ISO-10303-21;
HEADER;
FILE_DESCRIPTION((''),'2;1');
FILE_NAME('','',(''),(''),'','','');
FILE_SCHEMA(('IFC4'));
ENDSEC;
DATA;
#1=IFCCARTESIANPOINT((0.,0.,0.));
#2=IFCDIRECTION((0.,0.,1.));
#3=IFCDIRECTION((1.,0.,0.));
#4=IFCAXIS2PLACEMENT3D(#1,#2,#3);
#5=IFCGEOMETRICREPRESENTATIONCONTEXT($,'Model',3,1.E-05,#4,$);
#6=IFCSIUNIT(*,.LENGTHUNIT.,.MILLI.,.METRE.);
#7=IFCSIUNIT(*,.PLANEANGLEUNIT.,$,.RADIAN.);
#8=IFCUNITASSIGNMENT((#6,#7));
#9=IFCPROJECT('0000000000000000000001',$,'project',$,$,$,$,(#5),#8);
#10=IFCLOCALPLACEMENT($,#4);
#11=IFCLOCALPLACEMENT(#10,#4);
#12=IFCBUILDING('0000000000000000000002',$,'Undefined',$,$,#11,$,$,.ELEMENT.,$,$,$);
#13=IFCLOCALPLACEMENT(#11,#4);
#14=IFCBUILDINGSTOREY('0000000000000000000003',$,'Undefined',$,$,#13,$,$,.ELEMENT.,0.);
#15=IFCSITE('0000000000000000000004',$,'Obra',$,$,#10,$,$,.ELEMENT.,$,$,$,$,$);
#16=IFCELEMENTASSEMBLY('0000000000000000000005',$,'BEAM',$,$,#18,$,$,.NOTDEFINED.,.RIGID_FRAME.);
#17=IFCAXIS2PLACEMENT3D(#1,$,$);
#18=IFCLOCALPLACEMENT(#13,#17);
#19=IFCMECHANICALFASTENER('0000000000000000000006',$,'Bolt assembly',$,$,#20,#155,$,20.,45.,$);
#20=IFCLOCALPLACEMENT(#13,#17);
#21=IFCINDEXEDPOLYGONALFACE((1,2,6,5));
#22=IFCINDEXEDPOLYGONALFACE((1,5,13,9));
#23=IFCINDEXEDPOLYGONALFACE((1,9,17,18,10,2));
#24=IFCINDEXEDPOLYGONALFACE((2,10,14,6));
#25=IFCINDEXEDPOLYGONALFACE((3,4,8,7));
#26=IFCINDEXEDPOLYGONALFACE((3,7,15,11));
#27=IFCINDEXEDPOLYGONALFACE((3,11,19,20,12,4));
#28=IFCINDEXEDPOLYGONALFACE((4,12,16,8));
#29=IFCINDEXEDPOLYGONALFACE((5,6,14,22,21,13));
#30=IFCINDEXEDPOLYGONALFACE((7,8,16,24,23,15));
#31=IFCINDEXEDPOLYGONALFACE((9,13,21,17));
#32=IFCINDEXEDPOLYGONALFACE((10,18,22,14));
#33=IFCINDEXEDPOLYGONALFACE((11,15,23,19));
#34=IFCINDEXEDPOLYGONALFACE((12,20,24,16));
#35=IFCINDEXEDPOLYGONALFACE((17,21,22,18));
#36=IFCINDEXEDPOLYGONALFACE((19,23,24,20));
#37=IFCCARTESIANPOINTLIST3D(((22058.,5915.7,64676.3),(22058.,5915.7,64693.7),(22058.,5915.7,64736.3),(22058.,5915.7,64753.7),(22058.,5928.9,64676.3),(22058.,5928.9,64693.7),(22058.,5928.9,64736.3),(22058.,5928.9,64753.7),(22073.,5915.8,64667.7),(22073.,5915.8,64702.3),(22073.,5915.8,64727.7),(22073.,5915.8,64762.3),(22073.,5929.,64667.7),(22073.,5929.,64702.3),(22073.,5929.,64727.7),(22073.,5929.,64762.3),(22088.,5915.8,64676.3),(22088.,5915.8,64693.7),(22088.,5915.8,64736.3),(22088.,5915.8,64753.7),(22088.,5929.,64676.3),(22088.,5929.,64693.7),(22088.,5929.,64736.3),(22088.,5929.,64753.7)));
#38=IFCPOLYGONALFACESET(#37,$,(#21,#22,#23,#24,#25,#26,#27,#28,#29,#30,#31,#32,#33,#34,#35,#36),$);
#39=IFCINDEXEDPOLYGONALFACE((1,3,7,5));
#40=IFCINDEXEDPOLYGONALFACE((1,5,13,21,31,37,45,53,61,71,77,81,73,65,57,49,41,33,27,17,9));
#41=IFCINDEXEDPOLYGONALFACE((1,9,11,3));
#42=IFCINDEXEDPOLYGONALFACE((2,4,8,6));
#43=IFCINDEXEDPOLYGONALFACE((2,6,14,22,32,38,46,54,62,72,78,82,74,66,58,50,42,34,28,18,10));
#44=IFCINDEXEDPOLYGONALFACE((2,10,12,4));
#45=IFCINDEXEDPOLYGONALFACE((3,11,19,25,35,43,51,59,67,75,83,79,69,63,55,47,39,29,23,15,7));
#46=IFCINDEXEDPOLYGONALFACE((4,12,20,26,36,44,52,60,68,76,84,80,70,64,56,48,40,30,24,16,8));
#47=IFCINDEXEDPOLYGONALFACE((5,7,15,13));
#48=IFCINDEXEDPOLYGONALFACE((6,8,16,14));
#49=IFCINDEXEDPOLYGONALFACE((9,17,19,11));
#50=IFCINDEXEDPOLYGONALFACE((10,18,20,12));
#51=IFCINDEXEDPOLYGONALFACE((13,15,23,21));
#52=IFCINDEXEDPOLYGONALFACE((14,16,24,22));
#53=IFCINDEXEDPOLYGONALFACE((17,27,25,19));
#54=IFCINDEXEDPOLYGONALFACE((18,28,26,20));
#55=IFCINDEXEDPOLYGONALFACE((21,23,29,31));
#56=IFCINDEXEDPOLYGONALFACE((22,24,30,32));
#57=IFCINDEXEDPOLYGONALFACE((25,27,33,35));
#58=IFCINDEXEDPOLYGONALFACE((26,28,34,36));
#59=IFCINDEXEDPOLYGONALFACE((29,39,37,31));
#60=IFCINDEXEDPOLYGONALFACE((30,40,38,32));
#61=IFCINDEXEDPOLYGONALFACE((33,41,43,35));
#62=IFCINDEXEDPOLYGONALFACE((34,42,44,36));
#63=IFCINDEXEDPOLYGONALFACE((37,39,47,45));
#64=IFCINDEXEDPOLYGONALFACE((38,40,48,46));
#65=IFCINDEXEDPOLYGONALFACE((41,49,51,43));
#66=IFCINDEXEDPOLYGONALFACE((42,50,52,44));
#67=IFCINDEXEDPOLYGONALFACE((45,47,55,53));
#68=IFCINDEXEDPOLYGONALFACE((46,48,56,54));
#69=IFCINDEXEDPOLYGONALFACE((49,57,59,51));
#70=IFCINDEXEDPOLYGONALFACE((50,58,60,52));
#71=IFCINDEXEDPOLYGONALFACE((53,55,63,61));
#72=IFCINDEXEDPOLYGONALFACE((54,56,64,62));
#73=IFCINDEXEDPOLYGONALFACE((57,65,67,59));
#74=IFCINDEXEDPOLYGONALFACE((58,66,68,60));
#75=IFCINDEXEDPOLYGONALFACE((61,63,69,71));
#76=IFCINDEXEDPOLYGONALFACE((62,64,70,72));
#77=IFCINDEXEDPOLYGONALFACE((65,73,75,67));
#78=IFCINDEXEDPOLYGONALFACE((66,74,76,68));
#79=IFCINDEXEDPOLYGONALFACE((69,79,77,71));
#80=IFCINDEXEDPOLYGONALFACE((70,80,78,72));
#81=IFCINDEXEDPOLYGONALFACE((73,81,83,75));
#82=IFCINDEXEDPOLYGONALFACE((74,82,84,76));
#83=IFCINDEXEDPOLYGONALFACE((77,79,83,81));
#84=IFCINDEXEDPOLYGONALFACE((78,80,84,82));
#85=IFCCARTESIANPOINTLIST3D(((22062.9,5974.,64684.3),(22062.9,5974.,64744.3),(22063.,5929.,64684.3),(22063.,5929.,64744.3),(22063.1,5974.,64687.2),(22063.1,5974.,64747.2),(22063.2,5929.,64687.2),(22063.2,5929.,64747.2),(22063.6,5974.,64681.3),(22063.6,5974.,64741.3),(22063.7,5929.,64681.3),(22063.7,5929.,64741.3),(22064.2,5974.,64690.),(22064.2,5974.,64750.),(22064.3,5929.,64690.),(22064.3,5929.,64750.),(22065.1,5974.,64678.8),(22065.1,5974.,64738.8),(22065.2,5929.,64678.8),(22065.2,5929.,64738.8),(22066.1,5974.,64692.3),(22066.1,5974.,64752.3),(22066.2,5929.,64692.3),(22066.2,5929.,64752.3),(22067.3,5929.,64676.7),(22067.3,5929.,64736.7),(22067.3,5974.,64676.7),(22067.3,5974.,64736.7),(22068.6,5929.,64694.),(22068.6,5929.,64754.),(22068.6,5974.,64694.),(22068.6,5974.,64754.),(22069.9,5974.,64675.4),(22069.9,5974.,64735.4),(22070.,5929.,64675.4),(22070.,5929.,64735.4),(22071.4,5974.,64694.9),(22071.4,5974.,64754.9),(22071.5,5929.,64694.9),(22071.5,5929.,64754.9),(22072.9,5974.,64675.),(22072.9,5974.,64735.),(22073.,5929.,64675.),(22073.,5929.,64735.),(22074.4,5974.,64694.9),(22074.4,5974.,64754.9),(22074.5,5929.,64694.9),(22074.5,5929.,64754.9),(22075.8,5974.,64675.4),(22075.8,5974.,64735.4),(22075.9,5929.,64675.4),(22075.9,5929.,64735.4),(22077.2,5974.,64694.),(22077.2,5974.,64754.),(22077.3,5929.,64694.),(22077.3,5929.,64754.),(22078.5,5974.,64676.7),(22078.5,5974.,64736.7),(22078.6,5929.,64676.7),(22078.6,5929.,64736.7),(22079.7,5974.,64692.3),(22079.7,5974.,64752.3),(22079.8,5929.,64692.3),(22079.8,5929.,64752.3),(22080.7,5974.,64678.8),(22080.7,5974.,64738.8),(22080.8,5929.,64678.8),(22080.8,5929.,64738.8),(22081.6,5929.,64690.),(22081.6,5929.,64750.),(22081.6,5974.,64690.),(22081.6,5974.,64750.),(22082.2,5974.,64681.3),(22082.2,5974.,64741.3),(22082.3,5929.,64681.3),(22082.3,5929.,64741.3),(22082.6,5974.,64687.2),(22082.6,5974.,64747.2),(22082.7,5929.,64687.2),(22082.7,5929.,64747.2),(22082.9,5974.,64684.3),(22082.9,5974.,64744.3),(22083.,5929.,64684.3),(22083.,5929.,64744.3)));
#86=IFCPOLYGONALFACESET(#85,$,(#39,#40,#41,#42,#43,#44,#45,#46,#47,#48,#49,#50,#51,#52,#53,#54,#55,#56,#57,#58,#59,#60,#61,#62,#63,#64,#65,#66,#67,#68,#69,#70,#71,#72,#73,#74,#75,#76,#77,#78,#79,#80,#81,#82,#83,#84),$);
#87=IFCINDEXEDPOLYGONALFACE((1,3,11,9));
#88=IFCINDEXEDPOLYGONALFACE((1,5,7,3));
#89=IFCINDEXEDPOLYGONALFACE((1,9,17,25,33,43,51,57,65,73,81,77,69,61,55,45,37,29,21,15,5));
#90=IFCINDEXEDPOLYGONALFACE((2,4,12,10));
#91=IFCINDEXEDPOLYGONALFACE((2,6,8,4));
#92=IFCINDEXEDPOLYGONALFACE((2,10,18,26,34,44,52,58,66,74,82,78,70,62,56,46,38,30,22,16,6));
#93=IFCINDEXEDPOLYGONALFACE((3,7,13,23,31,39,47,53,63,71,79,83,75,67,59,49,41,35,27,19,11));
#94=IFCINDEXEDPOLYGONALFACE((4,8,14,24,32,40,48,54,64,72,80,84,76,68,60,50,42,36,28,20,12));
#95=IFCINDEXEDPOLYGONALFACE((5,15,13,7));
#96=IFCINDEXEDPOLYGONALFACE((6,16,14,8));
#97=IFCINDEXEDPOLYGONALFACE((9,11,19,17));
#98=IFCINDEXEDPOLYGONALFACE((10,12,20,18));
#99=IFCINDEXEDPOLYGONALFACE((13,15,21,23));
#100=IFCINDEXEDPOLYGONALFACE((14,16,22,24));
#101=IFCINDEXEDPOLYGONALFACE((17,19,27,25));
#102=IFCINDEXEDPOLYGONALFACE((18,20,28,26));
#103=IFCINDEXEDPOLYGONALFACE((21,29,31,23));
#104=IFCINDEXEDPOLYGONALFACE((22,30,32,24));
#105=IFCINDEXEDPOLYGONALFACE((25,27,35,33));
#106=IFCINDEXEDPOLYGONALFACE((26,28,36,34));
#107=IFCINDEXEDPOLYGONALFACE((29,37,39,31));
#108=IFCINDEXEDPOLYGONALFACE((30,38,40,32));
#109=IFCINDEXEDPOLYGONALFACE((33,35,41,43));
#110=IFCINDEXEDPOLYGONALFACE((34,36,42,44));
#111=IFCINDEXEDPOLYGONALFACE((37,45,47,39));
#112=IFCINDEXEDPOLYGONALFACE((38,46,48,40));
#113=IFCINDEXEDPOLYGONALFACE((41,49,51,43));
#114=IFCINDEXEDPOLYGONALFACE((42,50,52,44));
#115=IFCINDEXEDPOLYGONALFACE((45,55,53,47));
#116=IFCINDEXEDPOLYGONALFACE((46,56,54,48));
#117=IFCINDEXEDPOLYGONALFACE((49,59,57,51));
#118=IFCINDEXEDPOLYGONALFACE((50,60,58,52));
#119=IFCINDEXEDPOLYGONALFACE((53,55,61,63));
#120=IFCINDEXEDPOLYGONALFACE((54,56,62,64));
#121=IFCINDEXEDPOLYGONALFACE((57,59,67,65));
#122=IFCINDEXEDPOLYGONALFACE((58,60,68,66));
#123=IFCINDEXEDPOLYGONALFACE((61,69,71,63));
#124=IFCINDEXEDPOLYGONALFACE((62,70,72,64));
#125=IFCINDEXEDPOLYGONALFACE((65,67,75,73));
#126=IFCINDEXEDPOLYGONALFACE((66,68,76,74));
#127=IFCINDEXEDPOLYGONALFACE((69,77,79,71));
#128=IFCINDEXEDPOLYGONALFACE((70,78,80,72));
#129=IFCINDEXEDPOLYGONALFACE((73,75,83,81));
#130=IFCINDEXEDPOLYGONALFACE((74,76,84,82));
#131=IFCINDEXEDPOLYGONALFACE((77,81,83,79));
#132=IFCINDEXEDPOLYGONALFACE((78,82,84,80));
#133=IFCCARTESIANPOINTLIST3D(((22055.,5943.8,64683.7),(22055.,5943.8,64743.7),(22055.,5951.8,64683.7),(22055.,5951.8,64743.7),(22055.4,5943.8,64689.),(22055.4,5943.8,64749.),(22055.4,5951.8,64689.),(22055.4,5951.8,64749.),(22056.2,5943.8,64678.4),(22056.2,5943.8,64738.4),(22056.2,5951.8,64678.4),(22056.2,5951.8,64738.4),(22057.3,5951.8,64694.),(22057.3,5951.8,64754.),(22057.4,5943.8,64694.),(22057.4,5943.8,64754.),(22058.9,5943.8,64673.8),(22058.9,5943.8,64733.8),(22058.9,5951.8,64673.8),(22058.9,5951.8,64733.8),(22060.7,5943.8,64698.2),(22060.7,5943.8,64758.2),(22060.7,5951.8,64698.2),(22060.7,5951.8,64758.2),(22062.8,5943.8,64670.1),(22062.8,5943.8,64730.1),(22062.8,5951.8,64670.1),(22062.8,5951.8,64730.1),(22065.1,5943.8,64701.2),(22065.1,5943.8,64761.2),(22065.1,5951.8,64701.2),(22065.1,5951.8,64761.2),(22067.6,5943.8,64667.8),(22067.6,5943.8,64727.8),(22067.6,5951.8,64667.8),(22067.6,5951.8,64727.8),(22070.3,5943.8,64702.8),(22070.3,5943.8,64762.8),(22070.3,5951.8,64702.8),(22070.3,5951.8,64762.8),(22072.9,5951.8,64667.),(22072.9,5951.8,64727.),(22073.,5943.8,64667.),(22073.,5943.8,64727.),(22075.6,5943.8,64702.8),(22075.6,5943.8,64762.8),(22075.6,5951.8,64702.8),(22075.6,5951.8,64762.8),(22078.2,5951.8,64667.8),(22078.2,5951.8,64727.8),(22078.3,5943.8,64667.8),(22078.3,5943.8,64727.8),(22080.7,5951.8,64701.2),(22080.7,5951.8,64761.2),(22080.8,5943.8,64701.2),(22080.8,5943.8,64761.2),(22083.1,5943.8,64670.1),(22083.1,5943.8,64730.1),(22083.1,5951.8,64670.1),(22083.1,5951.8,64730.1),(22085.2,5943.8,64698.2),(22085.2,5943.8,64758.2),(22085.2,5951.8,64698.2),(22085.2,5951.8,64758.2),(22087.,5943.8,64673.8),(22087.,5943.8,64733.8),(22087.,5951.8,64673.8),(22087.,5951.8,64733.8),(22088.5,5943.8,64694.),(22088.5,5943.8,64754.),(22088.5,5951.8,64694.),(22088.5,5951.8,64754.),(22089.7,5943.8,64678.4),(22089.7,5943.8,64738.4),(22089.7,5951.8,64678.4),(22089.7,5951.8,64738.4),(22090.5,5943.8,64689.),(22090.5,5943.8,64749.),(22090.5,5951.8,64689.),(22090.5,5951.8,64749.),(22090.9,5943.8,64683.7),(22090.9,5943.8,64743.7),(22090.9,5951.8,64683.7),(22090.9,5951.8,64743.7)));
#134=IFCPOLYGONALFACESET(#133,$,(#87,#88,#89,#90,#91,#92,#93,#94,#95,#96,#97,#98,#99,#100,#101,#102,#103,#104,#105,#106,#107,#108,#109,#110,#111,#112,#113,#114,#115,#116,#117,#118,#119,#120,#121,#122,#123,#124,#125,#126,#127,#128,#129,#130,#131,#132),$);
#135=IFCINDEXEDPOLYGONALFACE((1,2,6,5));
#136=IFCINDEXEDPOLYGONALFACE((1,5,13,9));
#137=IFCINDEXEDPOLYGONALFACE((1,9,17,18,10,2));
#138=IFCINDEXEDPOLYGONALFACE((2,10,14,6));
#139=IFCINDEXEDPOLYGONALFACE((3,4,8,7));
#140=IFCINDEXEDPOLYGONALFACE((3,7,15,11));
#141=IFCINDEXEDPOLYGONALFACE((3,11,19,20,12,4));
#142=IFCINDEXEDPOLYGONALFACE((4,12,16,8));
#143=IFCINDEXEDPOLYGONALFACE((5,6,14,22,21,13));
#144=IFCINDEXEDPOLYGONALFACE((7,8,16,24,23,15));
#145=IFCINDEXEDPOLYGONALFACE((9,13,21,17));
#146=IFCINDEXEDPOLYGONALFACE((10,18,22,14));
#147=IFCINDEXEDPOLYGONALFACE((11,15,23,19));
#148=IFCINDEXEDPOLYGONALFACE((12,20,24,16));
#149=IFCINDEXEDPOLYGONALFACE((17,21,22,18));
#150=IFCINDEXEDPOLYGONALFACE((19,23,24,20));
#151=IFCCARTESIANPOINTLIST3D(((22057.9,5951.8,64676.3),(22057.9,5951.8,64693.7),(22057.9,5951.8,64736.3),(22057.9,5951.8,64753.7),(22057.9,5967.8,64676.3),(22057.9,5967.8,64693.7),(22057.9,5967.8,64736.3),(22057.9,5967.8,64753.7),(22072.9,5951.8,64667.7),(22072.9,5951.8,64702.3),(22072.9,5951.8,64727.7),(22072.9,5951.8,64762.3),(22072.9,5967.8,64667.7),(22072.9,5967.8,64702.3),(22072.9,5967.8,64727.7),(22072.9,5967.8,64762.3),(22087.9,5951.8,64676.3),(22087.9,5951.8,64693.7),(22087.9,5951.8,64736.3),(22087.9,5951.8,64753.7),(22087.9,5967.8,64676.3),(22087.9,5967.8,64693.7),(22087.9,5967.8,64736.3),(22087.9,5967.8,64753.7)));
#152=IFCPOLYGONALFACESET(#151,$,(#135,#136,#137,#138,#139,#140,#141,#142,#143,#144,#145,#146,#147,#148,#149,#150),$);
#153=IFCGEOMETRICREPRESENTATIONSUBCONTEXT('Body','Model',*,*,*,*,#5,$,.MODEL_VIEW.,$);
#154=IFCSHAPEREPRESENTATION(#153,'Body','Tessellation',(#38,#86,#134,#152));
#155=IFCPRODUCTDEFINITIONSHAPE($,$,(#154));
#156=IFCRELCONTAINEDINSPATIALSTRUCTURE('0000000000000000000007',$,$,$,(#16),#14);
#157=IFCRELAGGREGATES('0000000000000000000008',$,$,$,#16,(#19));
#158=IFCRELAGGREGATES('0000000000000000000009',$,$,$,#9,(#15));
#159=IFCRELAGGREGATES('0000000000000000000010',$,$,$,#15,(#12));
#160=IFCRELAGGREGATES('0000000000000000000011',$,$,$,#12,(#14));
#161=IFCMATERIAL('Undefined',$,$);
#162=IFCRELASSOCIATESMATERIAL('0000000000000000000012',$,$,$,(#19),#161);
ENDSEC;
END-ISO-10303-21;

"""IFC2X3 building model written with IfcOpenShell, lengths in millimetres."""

from ifc_helpers import new_model, si_unit, frame, origin_with_axes, origin_2d_with_axis, place, context, subcontext, project, spatial, polyline, circle, outline, extrude, source, transform, mapped, material, element, aggregate, save


model = new_model("IFC2X3")

# Units and contexts
model_context = context("Model", 3, precision=1e-05, world=origin_with_axes())
body_context = subcontext(model_context, "Body", "Model", "MODEL_VIEW")
ifc_project = project(units=[si_unit("LENGTHUNIT", "METRE", prefix="MILLI"), si_unit("PLANEANGLEUNIT", "RADIAN")], contexts=[model_context])

# Site, building, storey
site_placement = place(None, origin_with_axes())
site = spatial("IfcSite", under=ifc_project, at=site_placement, Name="Obra", CompositionType="ELEMENT")
building_placement = place(site_placement, origin_with_axes())
building = spatial("IfcBuilding", under=site, at=building_placement, Name="Undefined", CompositionType="ELEMENT")
storey_placement = place(building_placement, origin_with_axes())
storey = spatial("IfcBuildingStorey", under=building, at=storey_placement, Name="Undefined", CompositionType="ELEMENT", Elevation=0.0)

# Shared definitions
ifc_material = material(Name="Undefined")

# Element assembly, mechanical fastener
assembly_1_placement = place(storey_placement, origin_with_axes())
assembly_1 = element("IfcElementAssembly", 1, at=assembly_1_placement, inside=storey, Name="BEAM", AssemblyPlace="NOTDEFINED", PredefinedType="RIGID_FRAME")
shared_shape_1 = source(origin_with_axes(), body_context, "Body", "SweptSolid", [
    extrude(outline(polyline([(17.3, 0.0), (8.7, 15.0), (-8.7, 15.0), (-17.3, 0.0), (-8.7, -15.0), (8.7, -15.0), (17.3, 0.0)])), frame((0.0, -24.7, 0.0), z_axis=(0.0, 1.0, 0.0), x_axis=(1.0, 0.0, 0.0)), (0.0, 0.0, 1.0), 13.2),
    extrude(circle(Radius=10.0, at=origin_2d_with_axis()), frame((0.0, -11.5, 0.0), z_axis=(0.0, 1.0, 0.0), x_axis=(1.0, 0.0, 0.0)), (0.0, 0.0, 1.0), 45.0),
    extrude(circle(Radius=18.0, at=origin_2d_with_axis()), frame((0.0, 3.3, 0.0), z_axis=(0.0, 1.0, 0.0), x_axis=(1.0, 0.0, 0.0)), (0.0, 0.0, 1.0), 8.0),
    extrude(outline(polyline([(17.3, 0.0), (8.7, 15.0), (-8.7, 15.0), (-17.3, 0.0), (-8.7, -15.0), (8.7, -15.0), (17.3, 0.0)])), frame((0.0, 11.3, 0.0), z_axis=(0.0, 1.0, 0.0), x_axis=(1.0, 0.0, 0.0)), (0.0, 0.0, 1.0), 16.0),
])
mechanical_fastener_1_placement = place(assembly_1_placement, frame((22033.0, 5940.4, 64850.0), z_axis=(0.999998, 0.00197, 0.0), x_axis=(0.0, 0.0, -1.0)))
mechanical_fastener_1 = element("IfcMechanicalFastener", 2, at=mechanical_fastener_1_placement, material=ifc_material, Name="Bolt assembly", NominalDiameter=20.0, NominalLength=45.0, context=body_context, shape_type="MappedRepresentation", body=[
    mapped(shared_shape_1, transform((105.0, 0.0, 40.0))),
    mapped(shared_shape_1, transform((165.0, 0.0, 40.0))),
])
aggregate(assembly_1, [mechanical_fastener_1])

save(model, "model.ifc")
